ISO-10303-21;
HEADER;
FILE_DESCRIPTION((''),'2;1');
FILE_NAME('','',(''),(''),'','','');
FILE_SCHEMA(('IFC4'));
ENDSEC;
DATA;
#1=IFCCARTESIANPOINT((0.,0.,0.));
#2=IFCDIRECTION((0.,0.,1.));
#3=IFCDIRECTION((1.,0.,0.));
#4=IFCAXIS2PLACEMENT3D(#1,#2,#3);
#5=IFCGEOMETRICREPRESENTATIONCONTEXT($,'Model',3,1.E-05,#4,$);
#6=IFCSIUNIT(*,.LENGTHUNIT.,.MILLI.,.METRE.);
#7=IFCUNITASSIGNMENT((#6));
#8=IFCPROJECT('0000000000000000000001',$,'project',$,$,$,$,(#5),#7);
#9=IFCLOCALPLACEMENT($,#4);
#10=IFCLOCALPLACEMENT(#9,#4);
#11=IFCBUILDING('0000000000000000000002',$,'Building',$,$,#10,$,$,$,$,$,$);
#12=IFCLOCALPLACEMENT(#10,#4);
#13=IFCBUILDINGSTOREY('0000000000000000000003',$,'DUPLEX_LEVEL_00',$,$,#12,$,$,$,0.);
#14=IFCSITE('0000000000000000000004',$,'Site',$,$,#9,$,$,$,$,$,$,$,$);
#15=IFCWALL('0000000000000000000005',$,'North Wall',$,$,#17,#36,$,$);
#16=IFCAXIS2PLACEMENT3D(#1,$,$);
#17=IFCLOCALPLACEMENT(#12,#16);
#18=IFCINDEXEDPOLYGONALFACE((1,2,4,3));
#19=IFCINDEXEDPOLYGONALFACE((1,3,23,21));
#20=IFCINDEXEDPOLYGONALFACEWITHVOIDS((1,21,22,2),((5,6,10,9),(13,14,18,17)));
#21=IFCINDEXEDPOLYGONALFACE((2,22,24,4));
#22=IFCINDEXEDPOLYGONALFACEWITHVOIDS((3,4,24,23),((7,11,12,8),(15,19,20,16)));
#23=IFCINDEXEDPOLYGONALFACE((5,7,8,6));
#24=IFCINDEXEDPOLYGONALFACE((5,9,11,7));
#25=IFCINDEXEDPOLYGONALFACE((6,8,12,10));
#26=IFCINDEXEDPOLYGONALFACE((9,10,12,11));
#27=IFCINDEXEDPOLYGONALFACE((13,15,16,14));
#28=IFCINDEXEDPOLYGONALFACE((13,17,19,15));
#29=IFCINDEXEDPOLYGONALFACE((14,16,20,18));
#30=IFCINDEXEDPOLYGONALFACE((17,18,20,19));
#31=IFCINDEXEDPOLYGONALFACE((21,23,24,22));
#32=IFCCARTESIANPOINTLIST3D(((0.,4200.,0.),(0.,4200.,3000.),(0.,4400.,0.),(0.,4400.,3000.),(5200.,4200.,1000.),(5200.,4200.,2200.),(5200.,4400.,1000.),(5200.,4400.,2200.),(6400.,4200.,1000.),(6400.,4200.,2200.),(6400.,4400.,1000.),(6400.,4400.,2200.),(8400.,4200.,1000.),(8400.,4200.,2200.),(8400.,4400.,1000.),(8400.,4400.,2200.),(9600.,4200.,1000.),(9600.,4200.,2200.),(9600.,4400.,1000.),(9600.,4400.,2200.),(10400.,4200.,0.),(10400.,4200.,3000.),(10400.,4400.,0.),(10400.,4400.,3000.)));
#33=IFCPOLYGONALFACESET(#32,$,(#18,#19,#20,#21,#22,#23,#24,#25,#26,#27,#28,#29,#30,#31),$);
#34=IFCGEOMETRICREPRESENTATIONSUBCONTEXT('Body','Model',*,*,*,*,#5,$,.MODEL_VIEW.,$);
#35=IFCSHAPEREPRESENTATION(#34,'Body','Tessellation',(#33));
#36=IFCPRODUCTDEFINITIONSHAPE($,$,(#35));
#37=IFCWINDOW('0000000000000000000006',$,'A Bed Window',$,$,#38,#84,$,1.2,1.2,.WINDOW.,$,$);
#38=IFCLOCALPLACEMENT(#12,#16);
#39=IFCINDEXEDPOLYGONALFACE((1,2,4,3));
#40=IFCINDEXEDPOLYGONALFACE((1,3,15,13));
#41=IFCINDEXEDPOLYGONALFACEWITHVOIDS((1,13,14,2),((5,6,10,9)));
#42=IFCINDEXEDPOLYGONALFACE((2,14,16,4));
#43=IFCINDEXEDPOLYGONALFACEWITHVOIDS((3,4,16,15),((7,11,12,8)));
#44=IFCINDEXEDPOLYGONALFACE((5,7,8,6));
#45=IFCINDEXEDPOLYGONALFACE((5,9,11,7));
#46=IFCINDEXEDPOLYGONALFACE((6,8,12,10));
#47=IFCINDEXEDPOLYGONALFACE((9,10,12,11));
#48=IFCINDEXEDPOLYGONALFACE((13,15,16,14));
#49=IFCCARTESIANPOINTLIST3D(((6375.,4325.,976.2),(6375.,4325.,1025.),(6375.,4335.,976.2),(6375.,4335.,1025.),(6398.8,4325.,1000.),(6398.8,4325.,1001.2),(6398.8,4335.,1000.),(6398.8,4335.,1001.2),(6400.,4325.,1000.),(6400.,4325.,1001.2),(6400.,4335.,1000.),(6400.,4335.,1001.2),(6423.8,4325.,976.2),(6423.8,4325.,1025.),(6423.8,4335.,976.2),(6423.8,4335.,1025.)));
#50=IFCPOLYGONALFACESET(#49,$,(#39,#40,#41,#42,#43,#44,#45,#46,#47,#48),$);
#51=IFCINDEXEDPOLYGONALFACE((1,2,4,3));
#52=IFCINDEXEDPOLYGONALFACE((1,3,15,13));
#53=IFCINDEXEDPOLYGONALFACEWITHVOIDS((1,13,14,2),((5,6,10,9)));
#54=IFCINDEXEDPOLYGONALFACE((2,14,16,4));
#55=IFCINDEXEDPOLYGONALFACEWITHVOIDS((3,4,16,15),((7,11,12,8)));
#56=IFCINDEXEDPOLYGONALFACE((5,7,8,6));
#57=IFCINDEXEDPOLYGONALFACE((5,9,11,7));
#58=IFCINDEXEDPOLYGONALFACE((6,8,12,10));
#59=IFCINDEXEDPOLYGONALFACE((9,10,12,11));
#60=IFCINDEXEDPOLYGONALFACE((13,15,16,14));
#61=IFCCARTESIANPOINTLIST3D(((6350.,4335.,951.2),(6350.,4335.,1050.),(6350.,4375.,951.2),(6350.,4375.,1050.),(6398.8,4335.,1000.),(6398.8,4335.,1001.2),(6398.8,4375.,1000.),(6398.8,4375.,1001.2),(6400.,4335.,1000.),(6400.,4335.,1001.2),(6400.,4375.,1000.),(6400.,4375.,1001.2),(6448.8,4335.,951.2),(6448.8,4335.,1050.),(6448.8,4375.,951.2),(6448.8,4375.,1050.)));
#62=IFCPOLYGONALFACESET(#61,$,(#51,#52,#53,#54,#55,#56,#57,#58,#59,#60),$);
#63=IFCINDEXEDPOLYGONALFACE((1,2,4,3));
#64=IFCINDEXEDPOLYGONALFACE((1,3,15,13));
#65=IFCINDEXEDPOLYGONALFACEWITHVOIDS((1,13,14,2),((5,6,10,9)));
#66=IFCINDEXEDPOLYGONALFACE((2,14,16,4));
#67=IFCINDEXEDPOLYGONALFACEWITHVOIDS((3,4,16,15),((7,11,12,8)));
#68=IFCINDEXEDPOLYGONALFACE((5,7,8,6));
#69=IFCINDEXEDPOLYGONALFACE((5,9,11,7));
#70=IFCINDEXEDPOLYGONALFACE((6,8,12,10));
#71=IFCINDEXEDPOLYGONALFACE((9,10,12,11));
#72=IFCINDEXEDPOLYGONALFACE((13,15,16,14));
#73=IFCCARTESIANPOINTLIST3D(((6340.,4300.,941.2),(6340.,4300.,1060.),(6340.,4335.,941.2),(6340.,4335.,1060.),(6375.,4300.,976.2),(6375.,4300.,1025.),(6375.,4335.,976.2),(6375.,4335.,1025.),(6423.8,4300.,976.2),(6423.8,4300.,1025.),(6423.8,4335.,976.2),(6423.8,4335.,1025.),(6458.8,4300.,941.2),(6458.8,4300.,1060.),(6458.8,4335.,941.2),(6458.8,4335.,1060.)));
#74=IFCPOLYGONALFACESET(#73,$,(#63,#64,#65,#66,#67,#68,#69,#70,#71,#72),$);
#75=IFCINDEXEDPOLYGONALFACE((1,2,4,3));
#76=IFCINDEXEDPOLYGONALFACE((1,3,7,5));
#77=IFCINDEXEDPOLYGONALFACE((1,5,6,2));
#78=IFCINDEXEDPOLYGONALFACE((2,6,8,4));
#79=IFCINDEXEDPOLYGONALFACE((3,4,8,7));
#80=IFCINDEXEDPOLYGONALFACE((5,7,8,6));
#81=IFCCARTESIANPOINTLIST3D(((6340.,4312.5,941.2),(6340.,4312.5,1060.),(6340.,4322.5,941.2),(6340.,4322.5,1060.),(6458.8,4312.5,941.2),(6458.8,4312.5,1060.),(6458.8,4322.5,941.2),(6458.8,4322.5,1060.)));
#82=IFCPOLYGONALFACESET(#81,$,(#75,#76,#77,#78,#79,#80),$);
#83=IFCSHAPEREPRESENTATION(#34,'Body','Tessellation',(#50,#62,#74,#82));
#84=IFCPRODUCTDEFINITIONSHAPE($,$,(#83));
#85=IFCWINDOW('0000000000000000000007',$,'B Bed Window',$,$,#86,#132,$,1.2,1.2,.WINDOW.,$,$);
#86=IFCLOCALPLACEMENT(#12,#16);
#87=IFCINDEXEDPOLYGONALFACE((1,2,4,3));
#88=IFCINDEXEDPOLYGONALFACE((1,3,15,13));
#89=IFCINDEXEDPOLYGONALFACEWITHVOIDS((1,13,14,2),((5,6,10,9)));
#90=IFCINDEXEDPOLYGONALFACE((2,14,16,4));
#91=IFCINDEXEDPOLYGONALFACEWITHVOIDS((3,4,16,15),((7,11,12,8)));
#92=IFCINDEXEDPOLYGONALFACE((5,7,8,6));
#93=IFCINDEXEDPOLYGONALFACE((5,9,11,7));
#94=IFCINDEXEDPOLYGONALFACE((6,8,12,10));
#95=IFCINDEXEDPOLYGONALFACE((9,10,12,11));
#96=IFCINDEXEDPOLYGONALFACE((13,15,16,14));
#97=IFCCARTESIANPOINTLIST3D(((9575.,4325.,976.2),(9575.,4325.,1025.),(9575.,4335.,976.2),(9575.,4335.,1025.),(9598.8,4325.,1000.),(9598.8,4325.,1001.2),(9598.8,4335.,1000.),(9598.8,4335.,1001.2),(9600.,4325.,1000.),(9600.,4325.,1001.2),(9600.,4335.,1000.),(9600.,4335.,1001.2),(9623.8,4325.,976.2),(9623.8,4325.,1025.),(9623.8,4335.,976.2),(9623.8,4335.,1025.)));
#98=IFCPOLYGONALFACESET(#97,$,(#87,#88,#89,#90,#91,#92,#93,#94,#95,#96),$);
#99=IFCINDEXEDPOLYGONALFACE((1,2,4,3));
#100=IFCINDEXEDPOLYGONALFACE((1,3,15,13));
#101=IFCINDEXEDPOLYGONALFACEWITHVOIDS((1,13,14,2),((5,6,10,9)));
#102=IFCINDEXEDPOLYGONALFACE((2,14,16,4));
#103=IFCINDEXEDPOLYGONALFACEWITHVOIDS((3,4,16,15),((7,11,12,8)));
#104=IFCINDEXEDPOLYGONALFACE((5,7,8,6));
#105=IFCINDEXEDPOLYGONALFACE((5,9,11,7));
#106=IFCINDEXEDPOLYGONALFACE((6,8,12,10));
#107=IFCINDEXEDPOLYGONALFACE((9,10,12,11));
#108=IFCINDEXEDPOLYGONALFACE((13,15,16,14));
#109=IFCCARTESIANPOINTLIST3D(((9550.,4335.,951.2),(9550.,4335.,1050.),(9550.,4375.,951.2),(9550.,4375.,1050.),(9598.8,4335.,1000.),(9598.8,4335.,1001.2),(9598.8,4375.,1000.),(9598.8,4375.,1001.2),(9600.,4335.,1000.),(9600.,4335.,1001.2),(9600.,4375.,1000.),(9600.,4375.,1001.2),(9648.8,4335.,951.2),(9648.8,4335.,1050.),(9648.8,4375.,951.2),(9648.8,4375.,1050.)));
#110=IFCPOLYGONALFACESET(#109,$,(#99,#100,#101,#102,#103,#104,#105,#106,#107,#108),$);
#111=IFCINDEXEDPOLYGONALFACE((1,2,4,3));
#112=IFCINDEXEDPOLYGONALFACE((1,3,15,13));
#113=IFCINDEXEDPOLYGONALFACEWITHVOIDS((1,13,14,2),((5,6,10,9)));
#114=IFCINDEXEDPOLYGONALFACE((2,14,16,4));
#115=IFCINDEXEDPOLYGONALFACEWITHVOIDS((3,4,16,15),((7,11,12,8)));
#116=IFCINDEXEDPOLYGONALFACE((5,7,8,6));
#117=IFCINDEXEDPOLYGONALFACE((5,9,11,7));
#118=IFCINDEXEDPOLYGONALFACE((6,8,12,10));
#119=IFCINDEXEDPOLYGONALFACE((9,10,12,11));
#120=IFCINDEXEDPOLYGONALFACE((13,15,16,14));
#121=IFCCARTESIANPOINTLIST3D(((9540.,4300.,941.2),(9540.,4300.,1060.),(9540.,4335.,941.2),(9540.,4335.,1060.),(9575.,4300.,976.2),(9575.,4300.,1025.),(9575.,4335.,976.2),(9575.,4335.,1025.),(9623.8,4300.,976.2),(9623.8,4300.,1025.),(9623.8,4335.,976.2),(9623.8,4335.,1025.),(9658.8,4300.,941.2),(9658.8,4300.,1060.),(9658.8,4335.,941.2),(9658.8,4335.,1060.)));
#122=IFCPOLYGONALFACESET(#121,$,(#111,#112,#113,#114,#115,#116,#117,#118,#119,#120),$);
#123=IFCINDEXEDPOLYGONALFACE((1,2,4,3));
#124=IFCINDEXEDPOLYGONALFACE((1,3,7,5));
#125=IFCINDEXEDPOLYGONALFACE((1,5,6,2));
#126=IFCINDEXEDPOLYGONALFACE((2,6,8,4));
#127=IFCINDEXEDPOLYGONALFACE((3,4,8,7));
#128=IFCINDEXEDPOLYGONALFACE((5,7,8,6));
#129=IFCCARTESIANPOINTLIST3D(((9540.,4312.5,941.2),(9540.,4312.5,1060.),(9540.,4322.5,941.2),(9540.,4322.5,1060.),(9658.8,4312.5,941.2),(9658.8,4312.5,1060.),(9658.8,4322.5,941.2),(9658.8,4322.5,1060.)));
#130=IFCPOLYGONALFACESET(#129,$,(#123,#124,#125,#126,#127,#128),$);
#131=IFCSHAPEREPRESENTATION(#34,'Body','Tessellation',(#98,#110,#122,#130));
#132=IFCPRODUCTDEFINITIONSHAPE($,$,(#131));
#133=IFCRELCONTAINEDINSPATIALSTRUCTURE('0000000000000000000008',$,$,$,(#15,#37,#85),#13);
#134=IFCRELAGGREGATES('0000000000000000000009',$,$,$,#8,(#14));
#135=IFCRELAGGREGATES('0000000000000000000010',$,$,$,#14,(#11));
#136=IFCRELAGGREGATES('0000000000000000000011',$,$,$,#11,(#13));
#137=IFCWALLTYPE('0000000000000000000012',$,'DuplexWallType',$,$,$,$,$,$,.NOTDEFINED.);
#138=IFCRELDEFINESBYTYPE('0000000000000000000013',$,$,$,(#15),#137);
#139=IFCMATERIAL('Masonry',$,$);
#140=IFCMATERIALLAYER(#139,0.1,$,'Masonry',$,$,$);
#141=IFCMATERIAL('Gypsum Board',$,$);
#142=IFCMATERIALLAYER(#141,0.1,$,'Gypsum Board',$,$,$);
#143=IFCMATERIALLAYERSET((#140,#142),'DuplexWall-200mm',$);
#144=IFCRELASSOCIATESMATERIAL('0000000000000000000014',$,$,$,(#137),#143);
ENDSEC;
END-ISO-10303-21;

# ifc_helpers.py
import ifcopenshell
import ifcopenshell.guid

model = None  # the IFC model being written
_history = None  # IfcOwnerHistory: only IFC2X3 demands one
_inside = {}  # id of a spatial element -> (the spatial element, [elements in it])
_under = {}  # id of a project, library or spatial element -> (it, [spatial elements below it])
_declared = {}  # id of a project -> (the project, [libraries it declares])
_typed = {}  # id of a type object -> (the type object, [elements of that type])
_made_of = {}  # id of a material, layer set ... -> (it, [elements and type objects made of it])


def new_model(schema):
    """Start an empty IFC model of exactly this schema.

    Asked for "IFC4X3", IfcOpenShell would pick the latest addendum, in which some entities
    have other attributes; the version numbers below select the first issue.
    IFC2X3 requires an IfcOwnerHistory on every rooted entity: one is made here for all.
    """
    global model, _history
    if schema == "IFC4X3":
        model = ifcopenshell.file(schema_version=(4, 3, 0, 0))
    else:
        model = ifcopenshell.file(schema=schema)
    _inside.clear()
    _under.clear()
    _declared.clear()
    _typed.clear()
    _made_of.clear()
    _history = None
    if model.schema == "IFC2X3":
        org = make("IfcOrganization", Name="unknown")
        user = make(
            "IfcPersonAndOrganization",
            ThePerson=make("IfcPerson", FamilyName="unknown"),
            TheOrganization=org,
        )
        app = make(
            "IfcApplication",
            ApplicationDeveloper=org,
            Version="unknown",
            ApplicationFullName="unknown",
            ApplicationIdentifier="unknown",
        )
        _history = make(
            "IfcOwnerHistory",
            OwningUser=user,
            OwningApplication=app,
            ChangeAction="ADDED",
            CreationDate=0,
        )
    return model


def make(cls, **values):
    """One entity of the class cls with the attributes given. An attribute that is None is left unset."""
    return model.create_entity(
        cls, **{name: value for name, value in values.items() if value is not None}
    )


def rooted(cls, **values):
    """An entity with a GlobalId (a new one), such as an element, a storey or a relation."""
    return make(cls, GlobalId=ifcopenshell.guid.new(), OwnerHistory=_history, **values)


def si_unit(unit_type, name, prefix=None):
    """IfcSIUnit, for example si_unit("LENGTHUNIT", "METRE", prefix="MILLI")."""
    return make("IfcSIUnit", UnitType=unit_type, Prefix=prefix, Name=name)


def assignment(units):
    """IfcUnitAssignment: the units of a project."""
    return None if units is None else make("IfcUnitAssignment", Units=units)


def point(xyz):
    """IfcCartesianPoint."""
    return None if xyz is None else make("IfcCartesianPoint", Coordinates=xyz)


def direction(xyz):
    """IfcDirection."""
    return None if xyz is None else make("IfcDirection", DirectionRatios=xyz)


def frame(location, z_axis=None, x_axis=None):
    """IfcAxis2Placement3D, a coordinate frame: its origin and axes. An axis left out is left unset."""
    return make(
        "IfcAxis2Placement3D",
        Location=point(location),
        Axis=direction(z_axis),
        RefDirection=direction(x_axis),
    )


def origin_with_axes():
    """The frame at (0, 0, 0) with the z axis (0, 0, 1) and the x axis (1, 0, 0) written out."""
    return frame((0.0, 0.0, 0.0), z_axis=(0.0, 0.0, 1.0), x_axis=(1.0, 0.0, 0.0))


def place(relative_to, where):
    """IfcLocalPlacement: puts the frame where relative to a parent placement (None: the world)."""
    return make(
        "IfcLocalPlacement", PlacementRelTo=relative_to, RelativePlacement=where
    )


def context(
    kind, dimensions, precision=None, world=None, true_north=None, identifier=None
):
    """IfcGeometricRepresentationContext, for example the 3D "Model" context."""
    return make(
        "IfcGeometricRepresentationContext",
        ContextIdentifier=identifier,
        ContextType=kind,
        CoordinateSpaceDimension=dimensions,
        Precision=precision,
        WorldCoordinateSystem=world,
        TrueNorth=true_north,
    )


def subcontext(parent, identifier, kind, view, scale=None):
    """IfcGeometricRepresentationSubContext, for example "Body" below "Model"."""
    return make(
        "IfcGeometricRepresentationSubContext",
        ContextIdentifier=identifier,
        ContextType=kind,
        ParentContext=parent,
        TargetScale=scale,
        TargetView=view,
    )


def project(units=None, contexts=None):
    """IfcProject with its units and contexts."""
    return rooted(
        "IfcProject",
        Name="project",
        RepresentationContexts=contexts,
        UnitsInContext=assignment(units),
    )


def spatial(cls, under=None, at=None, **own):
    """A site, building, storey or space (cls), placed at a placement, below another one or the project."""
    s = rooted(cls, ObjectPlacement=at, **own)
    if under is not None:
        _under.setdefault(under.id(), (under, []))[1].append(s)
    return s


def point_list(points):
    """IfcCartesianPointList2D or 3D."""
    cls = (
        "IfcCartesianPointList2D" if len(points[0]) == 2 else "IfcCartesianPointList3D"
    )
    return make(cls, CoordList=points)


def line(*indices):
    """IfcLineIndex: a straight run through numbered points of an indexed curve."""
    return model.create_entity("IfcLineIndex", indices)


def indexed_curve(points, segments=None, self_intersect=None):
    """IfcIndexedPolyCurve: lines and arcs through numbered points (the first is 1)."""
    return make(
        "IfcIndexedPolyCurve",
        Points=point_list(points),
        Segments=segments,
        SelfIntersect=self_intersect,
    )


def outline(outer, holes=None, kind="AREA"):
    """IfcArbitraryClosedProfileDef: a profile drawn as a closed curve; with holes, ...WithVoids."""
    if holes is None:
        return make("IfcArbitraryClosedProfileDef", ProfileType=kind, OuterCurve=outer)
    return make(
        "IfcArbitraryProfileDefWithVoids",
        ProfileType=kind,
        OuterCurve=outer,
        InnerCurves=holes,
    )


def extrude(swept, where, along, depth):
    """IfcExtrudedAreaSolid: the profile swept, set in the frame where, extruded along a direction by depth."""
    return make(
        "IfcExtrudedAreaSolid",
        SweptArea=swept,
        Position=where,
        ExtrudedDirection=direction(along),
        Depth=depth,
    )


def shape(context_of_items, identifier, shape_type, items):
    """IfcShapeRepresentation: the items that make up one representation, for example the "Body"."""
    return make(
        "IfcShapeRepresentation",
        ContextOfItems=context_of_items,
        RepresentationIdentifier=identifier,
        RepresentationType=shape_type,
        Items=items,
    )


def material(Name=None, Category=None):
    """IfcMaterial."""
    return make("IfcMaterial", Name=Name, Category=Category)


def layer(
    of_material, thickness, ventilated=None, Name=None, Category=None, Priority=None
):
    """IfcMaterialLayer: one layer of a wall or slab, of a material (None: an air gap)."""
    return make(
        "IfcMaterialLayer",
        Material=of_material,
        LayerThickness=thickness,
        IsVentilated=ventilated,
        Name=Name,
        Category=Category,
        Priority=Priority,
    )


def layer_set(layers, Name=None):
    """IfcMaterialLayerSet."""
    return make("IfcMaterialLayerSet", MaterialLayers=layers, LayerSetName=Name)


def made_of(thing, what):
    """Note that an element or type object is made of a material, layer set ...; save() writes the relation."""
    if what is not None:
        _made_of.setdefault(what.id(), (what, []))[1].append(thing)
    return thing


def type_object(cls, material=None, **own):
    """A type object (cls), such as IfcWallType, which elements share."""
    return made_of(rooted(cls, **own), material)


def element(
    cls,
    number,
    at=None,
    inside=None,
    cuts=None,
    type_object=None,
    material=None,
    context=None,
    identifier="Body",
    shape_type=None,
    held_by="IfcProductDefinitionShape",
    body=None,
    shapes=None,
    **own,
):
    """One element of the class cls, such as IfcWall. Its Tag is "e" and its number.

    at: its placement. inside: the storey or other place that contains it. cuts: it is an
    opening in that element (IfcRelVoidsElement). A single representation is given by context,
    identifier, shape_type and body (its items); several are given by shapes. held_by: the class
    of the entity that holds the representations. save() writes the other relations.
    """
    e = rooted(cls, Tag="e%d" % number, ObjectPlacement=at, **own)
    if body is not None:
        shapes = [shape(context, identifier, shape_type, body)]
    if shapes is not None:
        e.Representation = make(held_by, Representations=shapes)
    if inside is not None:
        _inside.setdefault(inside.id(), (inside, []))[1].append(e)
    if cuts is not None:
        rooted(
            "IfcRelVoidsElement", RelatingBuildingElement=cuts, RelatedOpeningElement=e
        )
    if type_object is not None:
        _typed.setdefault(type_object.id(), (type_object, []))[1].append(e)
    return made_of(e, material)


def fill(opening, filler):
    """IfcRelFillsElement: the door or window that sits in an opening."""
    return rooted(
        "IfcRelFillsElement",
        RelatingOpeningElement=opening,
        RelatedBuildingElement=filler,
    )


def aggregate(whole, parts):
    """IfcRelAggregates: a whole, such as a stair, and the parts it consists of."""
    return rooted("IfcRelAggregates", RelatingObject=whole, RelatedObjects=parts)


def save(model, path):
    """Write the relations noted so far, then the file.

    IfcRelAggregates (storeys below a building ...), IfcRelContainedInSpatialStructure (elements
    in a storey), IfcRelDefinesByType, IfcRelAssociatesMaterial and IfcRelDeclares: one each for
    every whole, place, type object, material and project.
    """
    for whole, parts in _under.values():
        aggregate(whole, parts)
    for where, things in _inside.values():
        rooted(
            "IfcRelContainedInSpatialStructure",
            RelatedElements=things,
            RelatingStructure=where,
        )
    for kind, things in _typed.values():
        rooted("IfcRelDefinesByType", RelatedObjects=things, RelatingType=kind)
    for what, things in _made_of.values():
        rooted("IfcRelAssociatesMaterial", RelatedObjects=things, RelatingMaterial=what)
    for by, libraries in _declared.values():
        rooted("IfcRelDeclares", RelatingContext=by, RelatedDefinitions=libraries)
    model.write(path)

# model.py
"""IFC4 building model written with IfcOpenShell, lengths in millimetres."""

from ifc_helpers import new_model, si_unit, frame, origin_with_axes, place, context, subcontext, project, spatial, line, indexed_curve, outline, extrude, material, layer, layer_set, type_object, element, fill, save


model = new_model("IFC4")

# Units and contexts
model_context = context("Model", 3, precision=1e-05, world=origin_with_axes())
body_context = subcontext(model_context, "Body", "Model", "MODEL_VIEW")
ifc_project = project(units=[si_unit("LENGTHUNIT", "METRE", prefix="MILLI")], contexts=[model_context])

# Site, building, storey
site_placement = place(None, origin_with_axes())
site = spatial("IfcSite", under=ifc_project, at=site_placement, Name="Site")
building_placement = place(site_placement, origin_with_axes())
building = spatial("IfcBuilding", under=site, at=building_placement, Name="Building")
storey_placement = place(building_placement, origin_with_axes())
storey = spatial("IfcBuildingStorey", under=building, at=storey_placement, Name="DUPLEX_LEVEL_00", Elevation=0.0)

# Shared definitions
ifc_material_1 = material(Name="Masonry")
ifc_layer_1 = layer(ifc_material_1, 0.1, Name="Masonry")
ifc_material_2 = material(Name="Gypsum Board")
ifc_layer_2 = layer(ifc_material_2, 0.1, Name="Gypsum Board")
ifc_layer_set = layer_set([ifc_layer_1, ifc_layer_2], Name="DuplexWall-200mm")
wall_type = type_object("IfcWallType", Name="DuplexWallType", PredefinedType="NOTDEFINED", material=ifc_layer_set)

# Wall, openings, windows
wall_1_placement = place(storey_placement, frame((10400.0, 4400.0, 0.0), z_axis=(0.0, 0.0, 1.0), x_axis=(-1.0, 0.0, 0.0)))
wall_1 = element("IfcWall", 1, at=wall_1_placement, inside=storey, type_object=wall_type, Name="North Wall", context=body_context, shape_type="SweptSolid", body=[
    extrude(outline(indexed_curve([(0.0, 0.0), (0.0, 200.0), (10400.0, 200.0), (10400.0, 0.0), (0.0, 0.0)], self_intersect=False)), origin_with_axes(), (0.0, 0.0, 1.0), 3000.0),
])
opening_1_placement = place(wall_1_placement, frame((4000.0, -25.0, 1000.0), z_axis=(0.0, 0.0, 1.0), x_axis=(1.0, 0.0, 0.0)))
opening_1 = element("IfcOpeningElement", 2, at=opening_1_placement, cuts=wall_1, context=body_context, shape_type="SweptSolid", body=[
    extrude(outline(indexed_curve([(0.0, 0.0), (0.0, 250.0), (1200.0, 250.0), (1200.0, 0.0), (0.0, 0.0)], self_intersect=False)), origin_with_axes(), (0.0, 0.0, 1.0), 1200.0),
])
opening_2_placement = place(wall_1_placement, frame((800.0, -25.0, 1000.0), z_axis=(0.0, 0.0, 1.0), x_axis=(1.0, 0.0, 0.0)))
opening_2 = element("IfcOpeningElement", 3, at=opening_2_placement, cuts=wall_1, context=body_context, shape_type="SweptSolid", body=[
    extrude(outline(indexed_curve([(0.0, 0.0), (0.0, 250.0), (1200.0, 250.0), (1200.0, 0.0), (0.0, 0.0)], self_intersect=False)), origin_with_axes(), (0.0, 0.0, 1.0), 1200.0),
])
window_1_placement = place(storey_placement, frame((6400.0, 4425.0, 1000.0), z_axis=(0.0, 0.0, 1.0), x_axis=(-1.0, 0.0, 0.0)))
window_1 = element("IfcWindow", 4, at=window_1_placement, inside=storey, Name="A Bed Window", OverallHeight=1.2, OverallWidth=1.2, PredefinedType="WINDOW", context=body_context, shape_type="SweptSolid", body=[
    extrude(outline(indexed_curve([(0.0, 0.0), (1.2, 0.0), (1.2, 1.2), (0.0, 1.2)], segments=[line(1, 2, 3, 4, 1)]), holes=[indexed_curve([(25.0, 25.0), (-23.8, 25.0), (-23.8, -23.8), (25.0, -23.8)], segments=[line(1, 2, 3, 4, 1)])]), frame((0.0, 90.0, 0.0), z_axis=(0.0, -1.0, 0.0), x_axis=(1.0, 0.0, 0.0)), (0.0, 0.0, -1.0), 10.0),
    extrude(outline(indexed_curve([(0.0, 0.0), (1.2, 0.0), (1.2, 1.2), (0.0, 1.2)], segments=[line(1, 2, 3, 4, 1)]), holes=[indexed_curve([(50.0, 50.0), (-48.8, 50.0), (-48.8, -48.8), (50.0, -48.8)], segments=[line(1, 2, 3, 4, 1)])]), frame((0.0, 50.0, 0.0), z_axis=(0.0, -1.0, 0.0), x_axis=(1.0, 0.0, 0.0)), (0.0, 0.0, -1.0), 40.0),
    extrude(outline(indexed_curve([(0.0, 0.0), (-48.8, 0.0), (-48.8, -48.8), (0.0, -48.8)], segments=[line(1, 2, 3, 4, 1)]), holes=[indexed_curve([(35.0, 35.0), (-83.8, 35.0), (-83.8, -83.8), (35.0, -83.8)], segments=[line(1, 2, 3, 4, 1)])]), frame((25.0, 90.0, 25.0), z_axis=(0.0, -1.0, 0.0), x_axis=(1.0, 0.0, 0.0)), (0.0, 0.0, -1.0), 35.0),
    extrude(outline(indexed_curve([(35.0, 35.0), (-83.8, 35.0), (-83.8, -83.8), (35.0, -83.8)], segments=[line(1, 2, 3, 4, 1)])), frame((25.0, 102.5, 25.0), z_axis=(0.0, -1.0, 0.0), x_axis=(1.0, 0.0, 0.0)), (0.0, 0.0, -1.0), 10.0),
])
fill(opening_1, window_1)
window_2_placement = place(storey_placement, frame((9600.0, 4425.0, 1000.0), z_axis=(0.0, 0.0, 1.0), x_axis=(-1.0, 0.0, 0.0)))
window_2 = element("IfcWindow", 5, at=window_2_placement, inside=storey, Name="B Bed Window", OverallHeight=1.2, OverallWidth=1.2, PredefinedType="WINDOW", context=body_context, shape_type="SweptSolid", body=[
    extrude(outline(indexed_curve([(0.0, 0.0), (1.2, 0.0), (1.2, 1.2), (0.0, 1.2)], segments=[line(1, 2, 3, 4, 1)]), holes=[indexed_curve([(25.0, 25.0), (-23.8, 25.0), (-23.8, -23.8), (25.0, -23.8)], segments=[line(1, 2, 3, 4, 1)])]), frame((0.0, 90.0, 0.0), z_axis=(0.0, -1.0, 0.0), x_axis=(1.0, 0.0, 0.0)), (0.0, 0.0, -1.0), 10.0),
    extrude(outline(indexed_curve([(0.0, 0.0), (1.2, 0.0), (1.2, 1.2), (0.0, 1.2)], segments=[line(1, 2, 3, 4, 1)]), holes=[indexed_curve([(50.0, 50.0), (-48.8, 50.0), (-48.8, -48.8), (50.0, -48.8)], segments=[line(1, 2, 3, 4, 1)])]), frame((0.0, 50.0, 0.0), z_axis=(0.0, -1.0, 0.0), x_axis=(1.0, 0.0, 0.0)), (0.0, 0.0, -1.0), 40.0),
    extrude(outline(indexed_curve([(0.0, 0.0), (-48.8, 0.0), (-48.8, -48.8), (0.0, -48.8)], segments=[line(1, 2, 3, 4, 1)]), holes=[indexed_curve([(35.0, 35.0), (-83.8, 35.0), (-83.8, -83.8), (35.0, -83.8)], segments=[line(1, 2, 3, 4, 1)])]), frame((25.0, 90.0, 25.0), z_axis=(0.0, -1.0, 0.0), x_axis=(1.0, 0.0, 0.0)), (0.0, 0.0, -1.0), 35.0),
    extrude(outline(indexed_curve([(35.0, 35.0), (-83.8, 35.0), (-83.8, -83.8), (35.0, -83.8)], segments=[line(1, 2, 3, 4, 1)])), frame((25.0, 102.5, 25.0), z_axis=(0.0, -1.0, 0.0), x_axis=(1.0, 0.0, 0.0)), (0.0, 0.0, -1.0), 10.0),
])
fill(opening_2, window_2)

save(model, "model.ifc")
